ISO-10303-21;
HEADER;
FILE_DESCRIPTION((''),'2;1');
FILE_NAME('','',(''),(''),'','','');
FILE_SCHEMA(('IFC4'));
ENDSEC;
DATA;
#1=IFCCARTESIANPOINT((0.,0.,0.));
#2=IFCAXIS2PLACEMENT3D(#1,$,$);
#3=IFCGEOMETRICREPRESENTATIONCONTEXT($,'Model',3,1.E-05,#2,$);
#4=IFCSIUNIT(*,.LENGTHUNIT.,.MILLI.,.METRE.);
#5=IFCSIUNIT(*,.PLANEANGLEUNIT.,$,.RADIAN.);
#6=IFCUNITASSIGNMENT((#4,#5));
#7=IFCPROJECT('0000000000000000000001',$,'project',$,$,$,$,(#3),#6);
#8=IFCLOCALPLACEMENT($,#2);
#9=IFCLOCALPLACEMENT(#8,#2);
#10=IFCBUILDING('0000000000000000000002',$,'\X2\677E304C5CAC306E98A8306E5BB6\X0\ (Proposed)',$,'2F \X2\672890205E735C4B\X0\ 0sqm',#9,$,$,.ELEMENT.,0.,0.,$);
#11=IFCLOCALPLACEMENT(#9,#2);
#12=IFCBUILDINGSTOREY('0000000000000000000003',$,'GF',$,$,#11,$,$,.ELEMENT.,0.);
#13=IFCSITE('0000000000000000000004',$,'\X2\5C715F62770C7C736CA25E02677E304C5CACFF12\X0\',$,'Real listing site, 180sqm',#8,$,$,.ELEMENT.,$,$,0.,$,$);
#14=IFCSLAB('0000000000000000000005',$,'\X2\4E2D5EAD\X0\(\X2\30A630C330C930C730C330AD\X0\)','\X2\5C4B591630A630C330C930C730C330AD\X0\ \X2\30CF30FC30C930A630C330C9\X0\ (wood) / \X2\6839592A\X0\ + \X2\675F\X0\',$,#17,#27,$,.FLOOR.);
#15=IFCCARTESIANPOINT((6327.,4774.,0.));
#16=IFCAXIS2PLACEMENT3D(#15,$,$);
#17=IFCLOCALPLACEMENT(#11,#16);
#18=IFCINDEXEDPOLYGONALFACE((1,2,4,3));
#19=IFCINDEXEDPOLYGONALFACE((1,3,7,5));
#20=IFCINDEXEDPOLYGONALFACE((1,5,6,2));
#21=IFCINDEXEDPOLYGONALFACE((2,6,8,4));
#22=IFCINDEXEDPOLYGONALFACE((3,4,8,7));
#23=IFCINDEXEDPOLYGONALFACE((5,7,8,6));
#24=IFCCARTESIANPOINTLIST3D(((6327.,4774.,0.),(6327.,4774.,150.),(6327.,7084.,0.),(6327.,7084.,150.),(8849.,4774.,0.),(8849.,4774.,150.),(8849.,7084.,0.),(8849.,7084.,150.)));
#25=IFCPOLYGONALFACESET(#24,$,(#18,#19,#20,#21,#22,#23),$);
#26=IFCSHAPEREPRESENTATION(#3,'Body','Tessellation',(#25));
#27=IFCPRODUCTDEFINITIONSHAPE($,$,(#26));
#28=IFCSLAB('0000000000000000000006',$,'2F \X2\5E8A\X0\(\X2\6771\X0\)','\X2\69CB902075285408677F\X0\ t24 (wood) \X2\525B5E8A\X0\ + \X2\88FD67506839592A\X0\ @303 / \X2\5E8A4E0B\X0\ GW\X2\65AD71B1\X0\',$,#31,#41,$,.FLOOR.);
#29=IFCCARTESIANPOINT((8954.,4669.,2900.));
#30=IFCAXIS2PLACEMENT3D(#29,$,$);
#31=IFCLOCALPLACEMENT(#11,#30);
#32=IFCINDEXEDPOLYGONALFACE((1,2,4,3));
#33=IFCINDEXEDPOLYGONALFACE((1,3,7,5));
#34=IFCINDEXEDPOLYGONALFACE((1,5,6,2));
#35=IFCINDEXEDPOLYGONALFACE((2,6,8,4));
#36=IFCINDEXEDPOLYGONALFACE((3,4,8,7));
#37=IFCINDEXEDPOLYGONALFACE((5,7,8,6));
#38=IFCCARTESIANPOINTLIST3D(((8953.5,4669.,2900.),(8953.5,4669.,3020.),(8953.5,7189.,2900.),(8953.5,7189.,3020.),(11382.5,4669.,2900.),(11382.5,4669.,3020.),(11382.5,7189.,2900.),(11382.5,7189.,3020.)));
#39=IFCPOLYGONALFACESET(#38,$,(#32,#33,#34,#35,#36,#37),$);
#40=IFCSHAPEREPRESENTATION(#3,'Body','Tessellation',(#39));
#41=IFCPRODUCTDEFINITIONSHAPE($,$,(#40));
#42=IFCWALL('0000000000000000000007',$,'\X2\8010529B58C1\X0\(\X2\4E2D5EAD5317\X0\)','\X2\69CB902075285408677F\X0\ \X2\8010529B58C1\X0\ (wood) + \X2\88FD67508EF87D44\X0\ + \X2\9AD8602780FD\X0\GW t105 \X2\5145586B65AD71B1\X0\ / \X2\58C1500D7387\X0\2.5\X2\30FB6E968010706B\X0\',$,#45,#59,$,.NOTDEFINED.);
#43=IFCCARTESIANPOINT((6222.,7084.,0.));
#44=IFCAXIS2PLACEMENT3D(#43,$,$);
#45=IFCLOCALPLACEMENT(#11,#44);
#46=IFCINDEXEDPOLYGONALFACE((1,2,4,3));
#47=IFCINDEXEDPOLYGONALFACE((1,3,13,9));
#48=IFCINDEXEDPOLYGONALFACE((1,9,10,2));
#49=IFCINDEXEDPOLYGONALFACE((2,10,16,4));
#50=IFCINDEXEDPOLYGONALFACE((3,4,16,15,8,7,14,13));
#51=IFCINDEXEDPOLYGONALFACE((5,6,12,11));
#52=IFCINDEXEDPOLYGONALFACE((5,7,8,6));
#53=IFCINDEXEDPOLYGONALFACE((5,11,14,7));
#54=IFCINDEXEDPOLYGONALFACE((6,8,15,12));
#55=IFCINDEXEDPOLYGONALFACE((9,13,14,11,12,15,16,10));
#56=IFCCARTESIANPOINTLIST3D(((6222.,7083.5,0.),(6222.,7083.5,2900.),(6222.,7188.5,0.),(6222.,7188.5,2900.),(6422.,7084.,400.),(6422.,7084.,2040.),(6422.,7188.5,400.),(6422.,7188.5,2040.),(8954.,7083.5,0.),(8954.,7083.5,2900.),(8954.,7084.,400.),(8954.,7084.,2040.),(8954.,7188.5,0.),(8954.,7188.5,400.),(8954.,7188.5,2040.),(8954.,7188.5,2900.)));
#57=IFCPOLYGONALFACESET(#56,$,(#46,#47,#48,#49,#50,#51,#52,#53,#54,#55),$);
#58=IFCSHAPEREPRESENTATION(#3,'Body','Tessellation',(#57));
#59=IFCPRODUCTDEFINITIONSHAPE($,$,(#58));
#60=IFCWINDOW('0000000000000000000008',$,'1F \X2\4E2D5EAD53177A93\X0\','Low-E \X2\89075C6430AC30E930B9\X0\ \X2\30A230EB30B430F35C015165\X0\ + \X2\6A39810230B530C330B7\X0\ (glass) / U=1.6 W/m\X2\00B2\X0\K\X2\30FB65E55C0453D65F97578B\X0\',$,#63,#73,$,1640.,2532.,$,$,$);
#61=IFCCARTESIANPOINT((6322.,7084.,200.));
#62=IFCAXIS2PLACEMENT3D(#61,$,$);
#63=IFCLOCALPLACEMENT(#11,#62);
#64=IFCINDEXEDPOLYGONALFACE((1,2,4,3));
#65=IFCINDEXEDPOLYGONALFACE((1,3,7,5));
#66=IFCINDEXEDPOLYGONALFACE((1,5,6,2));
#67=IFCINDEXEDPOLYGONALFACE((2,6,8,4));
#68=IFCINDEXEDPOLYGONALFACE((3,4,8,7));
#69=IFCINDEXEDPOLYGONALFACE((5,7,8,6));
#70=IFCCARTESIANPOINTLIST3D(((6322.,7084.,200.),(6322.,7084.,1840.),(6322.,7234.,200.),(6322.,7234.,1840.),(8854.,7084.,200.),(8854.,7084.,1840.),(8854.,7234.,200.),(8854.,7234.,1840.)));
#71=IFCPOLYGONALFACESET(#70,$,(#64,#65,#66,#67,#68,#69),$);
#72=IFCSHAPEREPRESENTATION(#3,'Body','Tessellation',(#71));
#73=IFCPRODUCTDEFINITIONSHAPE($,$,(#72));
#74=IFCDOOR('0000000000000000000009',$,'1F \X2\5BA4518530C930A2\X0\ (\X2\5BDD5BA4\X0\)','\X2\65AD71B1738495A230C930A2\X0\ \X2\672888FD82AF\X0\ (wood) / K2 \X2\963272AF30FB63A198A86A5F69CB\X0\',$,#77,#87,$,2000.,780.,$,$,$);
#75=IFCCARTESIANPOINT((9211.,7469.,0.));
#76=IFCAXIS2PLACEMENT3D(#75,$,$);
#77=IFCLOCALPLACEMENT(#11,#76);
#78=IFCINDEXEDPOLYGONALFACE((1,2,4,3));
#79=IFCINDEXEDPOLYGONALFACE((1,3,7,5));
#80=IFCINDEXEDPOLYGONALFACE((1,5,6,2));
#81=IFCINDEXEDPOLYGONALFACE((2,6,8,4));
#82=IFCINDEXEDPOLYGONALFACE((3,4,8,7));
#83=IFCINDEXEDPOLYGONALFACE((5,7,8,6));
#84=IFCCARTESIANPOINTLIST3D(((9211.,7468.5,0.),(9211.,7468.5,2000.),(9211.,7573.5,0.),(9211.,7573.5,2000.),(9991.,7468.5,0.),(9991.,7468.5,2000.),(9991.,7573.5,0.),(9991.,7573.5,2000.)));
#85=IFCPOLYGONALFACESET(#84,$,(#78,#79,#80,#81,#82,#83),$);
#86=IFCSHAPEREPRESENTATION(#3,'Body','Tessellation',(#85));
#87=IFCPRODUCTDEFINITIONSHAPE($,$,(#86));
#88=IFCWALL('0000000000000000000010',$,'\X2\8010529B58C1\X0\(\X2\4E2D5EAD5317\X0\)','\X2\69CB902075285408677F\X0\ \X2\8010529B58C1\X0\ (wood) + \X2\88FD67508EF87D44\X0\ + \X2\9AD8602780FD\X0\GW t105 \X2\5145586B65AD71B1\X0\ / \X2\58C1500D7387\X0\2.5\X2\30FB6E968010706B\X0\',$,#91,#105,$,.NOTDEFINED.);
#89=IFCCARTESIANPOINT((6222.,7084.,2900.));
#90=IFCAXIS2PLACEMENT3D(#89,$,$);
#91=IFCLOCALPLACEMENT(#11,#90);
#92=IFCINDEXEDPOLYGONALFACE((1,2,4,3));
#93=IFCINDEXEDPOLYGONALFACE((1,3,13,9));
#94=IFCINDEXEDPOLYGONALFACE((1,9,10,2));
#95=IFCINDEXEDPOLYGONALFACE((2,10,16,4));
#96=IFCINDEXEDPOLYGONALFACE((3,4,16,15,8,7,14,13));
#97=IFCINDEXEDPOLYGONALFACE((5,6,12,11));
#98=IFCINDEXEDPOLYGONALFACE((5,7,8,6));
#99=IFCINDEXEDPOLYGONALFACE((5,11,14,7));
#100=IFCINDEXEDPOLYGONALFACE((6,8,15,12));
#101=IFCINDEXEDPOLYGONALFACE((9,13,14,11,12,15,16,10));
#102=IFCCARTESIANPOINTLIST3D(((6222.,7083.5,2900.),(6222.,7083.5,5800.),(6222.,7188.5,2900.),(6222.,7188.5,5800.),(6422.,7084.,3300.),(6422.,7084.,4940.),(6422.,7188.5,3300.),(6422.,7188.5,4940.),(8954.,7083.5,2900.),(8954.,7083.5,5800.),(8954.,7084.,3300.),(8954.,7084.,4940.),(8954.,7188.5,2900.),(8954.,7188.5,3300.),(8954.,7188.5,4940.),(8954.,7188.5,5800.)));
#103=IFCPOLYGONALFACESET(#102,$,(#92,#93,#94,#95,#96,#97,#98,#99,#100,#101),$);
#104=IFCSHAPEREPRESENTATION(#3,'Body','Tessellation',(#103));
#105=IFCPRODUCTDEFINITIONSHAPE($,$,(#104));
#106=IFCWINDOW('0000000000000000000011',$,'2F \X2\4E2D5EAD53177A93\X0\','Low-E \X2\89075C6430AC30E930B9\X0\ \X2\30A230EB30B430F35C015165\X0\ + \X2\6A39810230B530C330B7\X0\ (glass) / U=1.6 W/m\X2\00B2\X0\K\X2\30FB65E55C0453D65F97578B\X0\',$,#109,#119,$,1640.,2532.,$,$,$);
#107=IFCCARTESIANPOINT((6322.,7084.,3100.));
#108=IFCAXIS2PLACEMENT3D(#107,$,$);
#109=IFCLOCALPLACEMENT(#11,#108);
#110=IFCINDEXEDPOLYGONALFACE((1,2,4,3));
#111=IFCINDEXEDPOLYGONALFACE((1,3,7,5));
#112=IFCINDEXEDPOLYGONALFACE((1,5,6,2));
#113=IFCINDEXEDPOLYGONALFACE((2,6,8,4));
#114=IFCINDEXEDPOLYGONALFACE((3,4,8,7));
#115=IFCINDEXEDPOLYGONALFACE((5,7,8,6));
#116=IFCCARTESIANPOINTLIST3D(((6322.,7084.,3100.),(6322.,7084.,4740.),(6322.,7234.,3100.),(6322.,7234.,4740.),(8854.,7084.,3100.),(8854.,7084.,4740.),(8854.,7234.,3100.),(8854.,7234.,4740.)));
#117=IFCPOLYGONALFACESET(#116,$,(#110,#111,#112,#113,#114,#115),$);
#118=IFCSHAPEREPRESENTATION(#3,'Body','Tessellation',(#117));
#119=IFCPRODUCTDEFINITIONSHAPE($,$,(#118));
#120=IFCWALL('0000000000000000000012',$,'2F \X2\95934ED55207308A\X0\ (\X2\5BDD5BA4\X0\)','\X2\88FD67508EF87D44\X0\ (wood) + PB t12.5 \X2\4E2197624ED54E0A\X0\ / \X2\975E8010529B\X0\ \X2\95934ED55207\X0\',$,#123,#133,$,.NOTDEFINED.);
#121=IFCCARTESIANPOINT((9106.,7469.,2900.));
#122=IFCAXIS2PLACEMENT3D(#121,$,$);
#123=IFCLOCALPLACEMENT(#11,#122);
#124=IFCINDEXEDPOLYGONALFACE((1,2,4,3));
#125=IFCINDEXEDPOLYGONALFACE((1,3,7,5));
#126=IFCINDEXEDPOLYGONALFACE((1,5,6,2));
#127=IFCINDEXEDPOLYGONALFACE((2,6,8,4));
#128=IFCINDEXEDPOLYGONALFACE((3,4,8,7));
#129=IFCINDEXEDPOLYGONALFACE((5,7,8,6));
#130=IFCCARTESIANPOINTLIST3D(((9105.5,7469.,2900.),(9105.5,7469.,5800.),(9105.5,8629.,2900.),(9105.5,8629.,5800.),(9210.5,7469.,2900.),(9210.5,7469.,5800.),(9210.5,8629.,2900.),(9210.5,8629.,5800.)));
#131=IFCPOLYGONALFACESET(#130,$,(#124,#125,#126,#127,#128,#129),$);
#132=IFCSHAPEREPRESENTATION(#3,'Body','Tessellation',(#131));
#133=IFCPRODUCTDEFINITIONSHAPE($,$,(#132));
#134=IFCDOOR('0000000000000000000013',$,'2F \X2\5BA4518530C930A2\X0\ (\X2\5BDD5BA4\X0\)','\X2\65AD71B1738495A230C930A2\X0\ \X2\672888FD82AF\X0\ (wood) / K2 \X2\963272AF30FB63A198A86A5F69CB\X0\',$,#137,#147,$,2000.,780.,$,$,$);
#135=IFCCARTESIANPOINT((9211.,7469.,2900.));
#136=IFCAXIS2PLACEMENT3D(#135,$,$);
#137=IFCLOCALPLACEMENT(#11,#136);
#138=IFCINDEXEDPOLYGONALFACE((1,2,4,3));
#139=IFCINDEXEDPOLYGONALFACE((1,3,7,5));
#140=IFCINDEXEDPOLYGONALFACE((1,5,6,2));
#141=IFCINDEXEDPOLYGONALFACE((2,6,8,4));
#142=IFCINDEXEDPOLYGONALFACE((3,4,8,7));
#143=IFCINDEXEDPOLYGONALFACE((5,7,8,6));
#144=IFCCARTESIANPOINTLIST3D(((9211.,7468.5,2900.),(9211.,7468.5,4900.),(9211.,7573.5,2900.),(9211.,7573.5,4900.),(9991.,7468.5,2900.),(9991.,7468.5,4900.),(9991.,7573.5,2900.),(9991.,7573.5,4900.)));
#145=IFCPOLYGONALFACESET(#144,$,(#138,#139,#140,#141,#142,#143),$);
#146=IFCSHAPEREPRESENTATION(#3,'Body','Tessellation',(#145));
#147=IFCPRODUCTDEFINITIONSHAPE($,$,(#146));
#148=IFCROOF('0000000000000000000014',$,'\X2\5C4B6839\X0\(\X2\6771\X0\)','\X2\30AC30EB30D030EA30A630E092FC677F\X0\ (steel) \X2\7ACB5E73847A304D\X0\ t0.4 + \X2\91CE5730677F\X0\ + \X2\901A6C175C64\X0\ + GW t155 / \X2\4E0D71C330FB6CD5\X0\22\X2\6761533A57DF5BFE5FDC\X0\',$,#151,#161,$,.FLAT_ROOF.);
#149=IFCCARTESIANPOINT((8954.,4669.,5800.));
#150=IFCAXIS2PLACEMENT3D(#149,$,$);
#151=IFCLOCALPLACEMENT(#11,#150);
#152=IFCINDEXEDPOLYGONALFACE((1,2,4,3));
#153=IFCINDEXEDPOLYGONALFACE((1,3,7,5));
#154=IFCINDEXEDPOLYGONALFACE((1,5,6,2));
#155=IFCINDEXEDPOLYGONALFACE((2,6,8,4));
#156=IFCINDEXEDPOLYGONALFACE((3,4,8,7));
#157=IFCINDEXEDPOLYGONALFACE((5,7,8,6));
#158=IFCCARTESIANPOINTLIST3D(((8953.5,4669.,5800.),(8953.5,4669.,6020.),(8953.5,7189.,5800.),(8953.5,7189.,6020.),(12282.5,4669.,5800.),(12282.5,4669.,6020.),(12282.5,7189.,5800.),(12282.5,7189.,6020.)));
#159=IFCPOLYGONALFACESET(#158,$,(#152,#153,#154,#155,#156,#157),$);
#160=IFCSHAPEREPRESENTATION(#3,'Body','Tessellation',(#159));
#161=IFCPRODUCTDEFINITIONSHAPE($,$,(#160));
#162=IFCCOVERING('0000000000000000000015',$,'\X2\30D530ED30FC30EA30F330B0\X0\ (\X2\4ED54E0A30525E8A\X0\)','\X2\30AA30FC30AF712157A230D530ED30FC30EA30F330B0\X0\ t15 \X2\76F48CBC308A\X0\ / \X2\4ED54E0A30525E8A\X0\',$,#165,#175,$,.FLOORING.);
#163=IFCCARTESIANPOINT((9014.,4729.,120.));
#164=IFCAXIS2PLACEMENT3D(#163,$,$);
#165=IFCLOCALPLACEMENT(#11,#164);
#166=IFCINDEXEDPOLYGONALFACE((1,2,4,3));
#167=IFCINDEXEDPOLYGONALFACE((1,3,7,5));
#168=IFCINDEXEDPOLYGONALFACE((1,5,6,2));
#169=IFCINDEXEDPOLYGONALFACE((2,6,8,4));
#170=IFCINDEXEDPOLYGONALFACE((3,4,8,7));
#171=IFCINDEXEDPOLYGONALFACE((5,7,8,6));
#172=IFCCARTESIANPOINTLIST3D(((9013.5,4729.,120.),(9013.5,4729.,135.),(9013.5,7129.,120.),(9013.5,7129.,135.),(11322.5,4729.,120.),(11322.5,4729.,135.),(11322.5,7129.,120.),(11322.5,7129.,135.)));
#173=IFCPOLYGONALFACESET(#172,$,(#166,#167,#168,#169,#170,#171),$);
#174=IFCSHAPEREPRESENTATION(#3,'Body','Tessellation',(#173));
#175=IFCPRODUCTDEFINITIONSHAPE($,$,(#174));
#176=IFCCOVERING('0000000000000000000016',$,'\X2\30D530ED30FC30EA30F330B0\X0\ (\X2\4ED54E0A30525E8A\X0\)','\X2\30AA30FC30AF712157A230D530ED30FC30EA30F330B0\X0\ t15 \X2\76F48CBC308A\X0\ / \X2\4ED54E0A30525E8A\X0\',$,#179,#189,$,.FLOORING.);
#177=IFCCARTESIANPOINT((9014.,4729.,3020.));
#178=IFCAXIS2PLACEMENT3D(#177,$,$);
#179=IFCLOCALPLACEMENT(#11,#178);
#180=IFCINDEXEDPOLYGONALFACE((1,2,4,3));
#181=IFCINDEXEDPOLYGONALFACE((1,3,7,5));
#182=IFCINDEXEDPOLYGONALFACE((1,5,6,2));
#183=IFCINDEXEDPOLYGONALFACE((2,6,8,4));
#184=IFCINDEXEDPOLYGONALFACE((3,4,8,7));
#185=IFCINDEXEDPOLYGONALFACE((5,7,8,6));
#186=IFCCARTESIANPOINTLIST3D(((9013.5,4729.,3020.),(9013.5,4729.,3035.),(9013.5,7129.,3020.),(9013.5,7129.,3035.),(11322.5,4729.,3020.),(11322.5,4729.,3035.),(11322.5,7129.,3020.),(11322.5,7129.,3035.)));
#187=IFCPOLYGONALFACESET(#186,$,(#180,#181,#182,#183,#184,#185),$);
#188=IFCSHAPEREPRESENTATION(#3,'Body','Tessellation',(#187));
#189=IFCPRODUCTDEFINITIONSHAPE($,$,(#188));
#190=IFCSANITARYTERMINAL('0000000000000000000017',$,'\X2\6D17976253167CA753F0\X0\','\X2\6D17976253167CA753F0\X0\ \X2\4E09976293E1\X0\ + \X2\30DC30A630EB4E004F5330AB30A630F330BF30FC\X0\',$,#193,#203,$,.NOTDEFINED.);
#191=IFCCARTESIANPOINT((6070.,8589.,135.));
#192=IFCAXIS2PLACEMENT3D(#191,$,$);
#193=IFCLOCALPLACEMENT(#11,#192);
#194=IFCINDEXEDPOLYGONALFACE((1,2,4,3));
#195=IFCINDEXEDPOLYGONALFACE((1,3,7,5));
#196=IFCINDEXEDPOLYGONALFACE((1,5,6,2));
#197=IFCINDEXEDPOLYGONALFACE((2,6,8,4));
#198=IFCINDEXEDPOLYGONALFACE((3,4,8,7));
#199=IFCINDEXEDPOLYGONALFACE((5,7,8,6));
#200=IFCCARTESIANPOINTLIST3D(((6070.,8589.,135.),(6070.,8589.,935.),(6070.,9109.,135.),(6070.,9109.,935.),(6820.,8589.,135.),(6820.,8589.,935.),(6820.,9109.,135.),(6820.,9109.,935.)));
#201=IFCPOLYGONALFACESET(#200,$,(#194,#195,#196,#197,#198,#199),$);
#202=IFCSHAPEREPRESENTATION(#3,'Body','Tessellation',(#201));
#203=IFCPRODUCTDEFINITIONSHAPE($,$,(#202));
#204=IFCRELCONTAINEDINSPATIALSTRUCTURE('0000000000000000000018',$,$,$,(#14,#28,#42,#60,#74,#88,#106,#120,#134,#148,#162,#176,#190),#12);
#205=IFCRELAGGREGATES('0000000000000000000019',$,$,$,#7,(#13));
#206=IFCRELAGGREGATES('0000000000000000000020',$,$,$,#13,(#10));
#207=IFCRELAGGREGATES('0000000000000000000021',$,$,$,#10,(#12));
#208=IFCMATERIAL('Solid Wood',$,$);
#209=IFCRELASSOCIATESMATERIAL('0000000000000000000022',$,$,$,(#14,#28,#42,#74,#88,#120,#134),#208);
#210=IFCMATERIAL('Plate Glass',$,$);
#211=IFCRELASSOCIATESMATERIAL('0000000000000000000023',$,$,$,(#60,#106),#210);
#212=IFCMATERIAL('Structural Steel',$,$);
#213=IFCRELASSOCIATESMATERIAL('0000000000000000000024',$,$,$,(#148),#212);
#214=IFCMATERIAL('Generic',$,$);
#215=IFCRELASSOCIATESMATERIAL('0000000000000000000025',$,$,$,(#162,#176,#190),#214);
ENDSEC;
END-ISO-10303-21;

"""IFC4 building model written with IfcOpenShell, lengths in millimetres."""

from ifc_helpers import new_model, si_unit, frame, frame_2d, origin, place, context, project, spatial, rectangle, extrude, material, element, fill, save


model = new_model("IFC4")

# Units and contexts
model_context = context("Model", 3, precision=1e-05, world=origin())
ifc_project = project(units=[si_unit("LENGTHUNIT", "METRE", prefix="MILLI"), si_unit("PLANEANGLEUNIT", "RADIAN")], contexts=[model_context])

# Site, building, storey
site_placement = place(None, origin())
site = spatial("IfcSite", under=ifc_project, at=site_placement, Name="山形県米沢市松が岬２", ObjectType="Real listing site, 180sqm", CompositionType="ELEMENT", RefElevation=0.0)
building_placement = place(site_placement, origin())
building = spatial("IfcBuilding", under=site, at=building_placement, Name="松が岬の風の家 (Proposed)", ObjectType="2F 木造平屋 0sqm", CompositionType="ELEMENT", ElevationOfRefHeight=0.0, ElevationOfTerrain=0.0)
storey_placement = place(building_placement, origin())
storey = spatial("IfcBuildingStorey", under=building, at=storey_placement, Name="GF", CompositionType="ELEMENT", Elevation=0.0)

# Slabs
ifc_material_1 = material(Name="Solid Wood")
slab_1_placement = place(storey_placement, frame((6327.0, 4774.0, 0.0)))
element("IfcSlab", 1, at=slab_1_placement, inside=storey, material=ifc_material_1, Name="中庭(ウッドデッキ)", Description="屋外ウッドデッキ ハードウッド (wood) / 根太 + 束", PredefinedType="FLOOR", context=model_context, shape_type="SweptSolid", body=[
    extrude(rectangle(XDim=2522.0, YDim=2310.0, at=frame_2d((1261.0, 1155.0))), frame((6327.0, 4774.0, 0.0)), (0.0, 0.0, 1.0), 150.0),
])
slab_2_placement = place(storey_placement, frame((8954.0, 4669.0, 2900.0)))
element("IfcSlab", 2, at=slab_2_placement, inside=storey, material=ifc_material_1, Name="2F 床(東)", Description="構造用合板 t24 (wood) 剛床 + 製材根太 @303 / 床下 GW断熱", PredefinedType="FLOOR", context=model_context, shape_type="SweptSolid", body=[
    extrude(rectangle(XDim=2429.0, YDim=2520.0, at=frame_2d((1214.0, 1260.0))), frame((8954.0, 4669.0, 2900.0)), (0.0, 0.0, 1.0), 120.0),
])

# Wall, opening, window
wall_1_placement = place(storey_placement, frame((6222.0, 7084.0, 0.0)))
wall_1 = element("IfcWall", 3, at=wall_1_placement, inside=storey, material=ifc_material_1, Name="耐力壁(中庭北)", Description="構造用合板 耐力壁 (wood) + 製材軸組 + 高性能GW t105 充填断熱 / 壁倍率2.5・準耐火", PredefinedType="NOTDEFINED", context=model_context, shape_type="SweptSolid", body=[
    extrude(rectangle(XDim=2732.0, YDim=105.0, at=frame_2d((1366.0, 52.0))), frame((6222.0, 7084.0, 0.0)), (0.0, 0.0, 1.0), 2900.0),
])
opening_1_placement = place(storey_placement, frame((6322.0, 7084.0, 200.0)))
opening_1 = element("IfcOpeningElement", 4, at=opening_1_placement, cuts=wall_1, PredefinedType="NOTDEFINED", context=model_context, shape_type="SweptSolid", body=[
    extrude(rectangle(XDim=2532.0, YDim=150.0, at=frame_2d((1266.0, 75.0))), frame((6322.0, 7084.0, 200.0)), (0.0, 0.0, 1.0), 1640.0),
])
ifc_material_2 = material(Name="Plate Glass")
window_1_placement = place(storey_placement, frame((6322.0, 7084.0, 200.0)))
window_1 = element("IfcWindow", 5, at=window_1_placement, inside=storey, material=ifc_material_2, Name="1F 中庭北窓", Description="Low-E 複層ガラス アルゴン封入 + 樹脂サッシ (glass) / U=1.6 W/m²K・日射取得型", OverallHeight=1640.0, OverallWidth=2532.0, context=model_context, shape_type="SweptSolid", body=[
    extrude(rectangle(XDim=2532.0, YDim=150.0, at=frame_2d((1266.0, 75.0))), frame((6322.0, 7084.0, 200.0)), (0.0, 0.0, 1.0), 1640.0),
])
fill(opening_1, window_1)

# Door
door_1_placement = place(storey_placement, frame((9211.0, 7469.0, 0.0)))
element("IfcDoor", 6, at=door_1_placement, inside=storey, material=ifc_material_1, Name="1F 室内ドア (寝室)", Description="断熱玄関ドア 木製芯 (wood) / K2 防犯・採風機構", OverallHeight=2000.0, OverallWidth=780.0, context=model_context, shape_type="SweptSolid", body=[
    extrude(rectangle(XDim=780.0, YDim=105.0, at=frame_2d((390.0, 52.0))), frame((9211.0, 7469.0, 0.0)), (0.0, 0.0, 1.0), 2000.0),
])

# Wall, opening, window
wall_2_placement = place(storey_placement, frame((6222.0, 7084.0, 2900.0)))
wall_2 = element("IfcWall", 7, at=wall_2_placement, inside=storey, material=ifc_material_1, Name="耐力壁(中庭北)", Description="構造用合板 耐力壁 (wood) + 製材軸組 + 高性能GW t105 充填断熱 / 壁倍率2.5・準耐火", PredefinedType="NOTDEFINED", context=model_context, shape_type="SweptSolid", body=[
    extrude(rectangle(XDim=2732.0, YDim=105.0, at=frame_2d((1366.0, 52.0))), frame((6222.0, 7084.0, 2900.0)), (0.0, 0.0, 1.0), 2900.0),
])
opening_2_placement = place(storey_placement, frame((6322.0, 7084.0, 3100.0)))
opening_2 = element("IfcOpeningElement", 8, at=opening_2_placement, cuts=wall_2, PredefinedType="NOTDEFINED", context=model_context, shape_type="SweptSolid", body=[
    extrude(rectangle(XDim=2532.0, YDim=150.0, at=frame_2d((1266.0, 75.0))), frame((6322.0, 7084.0, 3100.0)), (0.0, 0.0, 1.0), 1640.0),
])
window_2_placement = place(storey_placement, frame((6322.0, 7084.0, 3100.0)))
window_2 = element("IfcWindow", 9, at=window_2_placement, inside=storey, material=ifc_material_2, Name="2F 中庭北窓", Description="Low-E 複層ガラス アルゴン封入 + 樹脂サッシ (glass) / U=1.6 W/m²K・日射取得型", OverallHeight=1640.0, OverallWidth=2532.0, context=model_context, shape_type="SweptSolid", body=[
    extrude(rectangle(XDim=2532.0, YDim=150.0, at=frame_2d((1266.0, 75.0))), frame((6322.0, 7084.0, 3100.0)), (0.0, 0.0, 1.0), 1640.0),
])
fill(opening_2, window_2)

# Wall
wall_3_placement = place(storey_placement, frame((9106.0, 7469.0, 2900.0)))
element("IfcWall", 10, at=wall_3_placement, inside=storey, material=ifc_material_1, Name="2F 間仕切り (寝室)", Description="製材軸組 (wood) + PB t12.5 両面仕上 / 非耐力 間仕切", PredefinedType="NOTDEFINED", context=model_context, shape_type="SweptSolid", body=[
    extrude(rectangle(XDim=105.0, YDim=1160.0, at=frame_2d((52.0, 580.0))), frame((9106.0, 7469.0, 2900.0)), (0.0, 0.0, 1.0), 2900.0),
])

# Door
door_2_placement = place(storey_placement, frame((9211.0, 7469.0, 2900.0)))
element("IfcDoor", 11, at=door_2_placement, inside=storey, material=ifc_material_1, Name="2F 室内ドア (寝室)", Description="断熱玄関ドア 木製芯 (wood) / K2 防犯・採風機構", OverallHeight=2000.0, OverallWidth=780.0, context=model_context, shape_type="SweptSolid", body=[
    extrude(rectangle(XDim=780.0, YDim=105.0, at=frame_2d((390.0, 52.0))), frame((9211.0, 7469.0, 2900.0)), (0.0, 0.0, 1.0), 2000.0),
])

# Roof
ifc_material_3 = material(Name="Structural Steel")
for number, where, name in (
    (12, (8954.0, 4669.0, 5800.0), "屋根(東)"),
):
    element("IfcRoof", number, at=place(storey_placement, frame(where)), inside=storey, material=ifc_material_3, Name=name, Description="ガルバリウム鋼板 (steel) 立平葺き t0.4 + 野地板 + 通気層 + GW t155 / 不燃・法22条区域対応", PredefinedType="FLAT_ROOF", context=model_context, shape_type="SweptSolid", body=[
        extrude(rectangle(XDim=3329.0, YDim=2520.0, at=frame_2d((1664.0, 1260.0))), frame((8954.0, 4669.0, 5800.0)), (0.0, 0.0, 1.0), 220.0),
    ])

# Coverings
ifc_material_4 = material(Name="Generic")
covering_1_placement = place(storey_placement, frame((9014.0, 4729.0, 120.0)))
element("IfcCovering", 13, at=covering_1_placement, inside=storey, material=ifc_material_4, Name="フローリング (仕上げ床)", Description="オーク無垢フローリング t15 直貼り / 仕上げ床", PredefinedType="FLOORING", context=model_context, shape_type="SweptSolid", body=[
    extrude(rectangle(XDim=2309.0, YDim=2400.0, at=frame_2d((1154.0, 1200.0))), frame((9014.0, 4729.0, 120.0)), (0.0, 0.0, 1.0), 15.0),
])
covering_2_placement = place(storey_placement, frame((9014.0, 4729.0, 3020.0)))
element("IfcCovering", 14, at=covering_2_placement, inside=storey, material=ifc_material_4, Name="フローリング (仕上げ床)", Description="オーク無垢フローリング t15 直貼り / 仕上げ床", PredefinedType="FLOORING", context=model_context, shape_type="SweptSolid", body=[
    extrude(rectangle(XDim=2309.0, YDim=2400.0, at=frame_2d((1154.0, 1200.0))), frame((9014.0, 4729.0, 3020.0)), (0.0, 0.0, 1.0), 15.0),
])

# Sanitary terminal
sanitary_terminal_1_placement = place(storey_placement, frame((6070.0, 8589.0, 135.0)))
element("IfcSanitaryTerminal", 15, at=sanitary_terminal_1_placement, inside=storey, material=ifc_material_4, Name="洗面化粧台", Description="洗面化粧台 三面鏡 + ボウル一体カウンター", PredefinedType="NOTDEFINED", context=model_context, shape_type="SweptSolid", body=[
    extrude(rectangle(XDim=750.0, YDim=520.0, at=frame_2d((375.0, 260.0))), frame((6070.0, 8589.0, 135.0)), (0.0, 0.0, 1.0), 800.0),
])

save(model, "model.ifc")
